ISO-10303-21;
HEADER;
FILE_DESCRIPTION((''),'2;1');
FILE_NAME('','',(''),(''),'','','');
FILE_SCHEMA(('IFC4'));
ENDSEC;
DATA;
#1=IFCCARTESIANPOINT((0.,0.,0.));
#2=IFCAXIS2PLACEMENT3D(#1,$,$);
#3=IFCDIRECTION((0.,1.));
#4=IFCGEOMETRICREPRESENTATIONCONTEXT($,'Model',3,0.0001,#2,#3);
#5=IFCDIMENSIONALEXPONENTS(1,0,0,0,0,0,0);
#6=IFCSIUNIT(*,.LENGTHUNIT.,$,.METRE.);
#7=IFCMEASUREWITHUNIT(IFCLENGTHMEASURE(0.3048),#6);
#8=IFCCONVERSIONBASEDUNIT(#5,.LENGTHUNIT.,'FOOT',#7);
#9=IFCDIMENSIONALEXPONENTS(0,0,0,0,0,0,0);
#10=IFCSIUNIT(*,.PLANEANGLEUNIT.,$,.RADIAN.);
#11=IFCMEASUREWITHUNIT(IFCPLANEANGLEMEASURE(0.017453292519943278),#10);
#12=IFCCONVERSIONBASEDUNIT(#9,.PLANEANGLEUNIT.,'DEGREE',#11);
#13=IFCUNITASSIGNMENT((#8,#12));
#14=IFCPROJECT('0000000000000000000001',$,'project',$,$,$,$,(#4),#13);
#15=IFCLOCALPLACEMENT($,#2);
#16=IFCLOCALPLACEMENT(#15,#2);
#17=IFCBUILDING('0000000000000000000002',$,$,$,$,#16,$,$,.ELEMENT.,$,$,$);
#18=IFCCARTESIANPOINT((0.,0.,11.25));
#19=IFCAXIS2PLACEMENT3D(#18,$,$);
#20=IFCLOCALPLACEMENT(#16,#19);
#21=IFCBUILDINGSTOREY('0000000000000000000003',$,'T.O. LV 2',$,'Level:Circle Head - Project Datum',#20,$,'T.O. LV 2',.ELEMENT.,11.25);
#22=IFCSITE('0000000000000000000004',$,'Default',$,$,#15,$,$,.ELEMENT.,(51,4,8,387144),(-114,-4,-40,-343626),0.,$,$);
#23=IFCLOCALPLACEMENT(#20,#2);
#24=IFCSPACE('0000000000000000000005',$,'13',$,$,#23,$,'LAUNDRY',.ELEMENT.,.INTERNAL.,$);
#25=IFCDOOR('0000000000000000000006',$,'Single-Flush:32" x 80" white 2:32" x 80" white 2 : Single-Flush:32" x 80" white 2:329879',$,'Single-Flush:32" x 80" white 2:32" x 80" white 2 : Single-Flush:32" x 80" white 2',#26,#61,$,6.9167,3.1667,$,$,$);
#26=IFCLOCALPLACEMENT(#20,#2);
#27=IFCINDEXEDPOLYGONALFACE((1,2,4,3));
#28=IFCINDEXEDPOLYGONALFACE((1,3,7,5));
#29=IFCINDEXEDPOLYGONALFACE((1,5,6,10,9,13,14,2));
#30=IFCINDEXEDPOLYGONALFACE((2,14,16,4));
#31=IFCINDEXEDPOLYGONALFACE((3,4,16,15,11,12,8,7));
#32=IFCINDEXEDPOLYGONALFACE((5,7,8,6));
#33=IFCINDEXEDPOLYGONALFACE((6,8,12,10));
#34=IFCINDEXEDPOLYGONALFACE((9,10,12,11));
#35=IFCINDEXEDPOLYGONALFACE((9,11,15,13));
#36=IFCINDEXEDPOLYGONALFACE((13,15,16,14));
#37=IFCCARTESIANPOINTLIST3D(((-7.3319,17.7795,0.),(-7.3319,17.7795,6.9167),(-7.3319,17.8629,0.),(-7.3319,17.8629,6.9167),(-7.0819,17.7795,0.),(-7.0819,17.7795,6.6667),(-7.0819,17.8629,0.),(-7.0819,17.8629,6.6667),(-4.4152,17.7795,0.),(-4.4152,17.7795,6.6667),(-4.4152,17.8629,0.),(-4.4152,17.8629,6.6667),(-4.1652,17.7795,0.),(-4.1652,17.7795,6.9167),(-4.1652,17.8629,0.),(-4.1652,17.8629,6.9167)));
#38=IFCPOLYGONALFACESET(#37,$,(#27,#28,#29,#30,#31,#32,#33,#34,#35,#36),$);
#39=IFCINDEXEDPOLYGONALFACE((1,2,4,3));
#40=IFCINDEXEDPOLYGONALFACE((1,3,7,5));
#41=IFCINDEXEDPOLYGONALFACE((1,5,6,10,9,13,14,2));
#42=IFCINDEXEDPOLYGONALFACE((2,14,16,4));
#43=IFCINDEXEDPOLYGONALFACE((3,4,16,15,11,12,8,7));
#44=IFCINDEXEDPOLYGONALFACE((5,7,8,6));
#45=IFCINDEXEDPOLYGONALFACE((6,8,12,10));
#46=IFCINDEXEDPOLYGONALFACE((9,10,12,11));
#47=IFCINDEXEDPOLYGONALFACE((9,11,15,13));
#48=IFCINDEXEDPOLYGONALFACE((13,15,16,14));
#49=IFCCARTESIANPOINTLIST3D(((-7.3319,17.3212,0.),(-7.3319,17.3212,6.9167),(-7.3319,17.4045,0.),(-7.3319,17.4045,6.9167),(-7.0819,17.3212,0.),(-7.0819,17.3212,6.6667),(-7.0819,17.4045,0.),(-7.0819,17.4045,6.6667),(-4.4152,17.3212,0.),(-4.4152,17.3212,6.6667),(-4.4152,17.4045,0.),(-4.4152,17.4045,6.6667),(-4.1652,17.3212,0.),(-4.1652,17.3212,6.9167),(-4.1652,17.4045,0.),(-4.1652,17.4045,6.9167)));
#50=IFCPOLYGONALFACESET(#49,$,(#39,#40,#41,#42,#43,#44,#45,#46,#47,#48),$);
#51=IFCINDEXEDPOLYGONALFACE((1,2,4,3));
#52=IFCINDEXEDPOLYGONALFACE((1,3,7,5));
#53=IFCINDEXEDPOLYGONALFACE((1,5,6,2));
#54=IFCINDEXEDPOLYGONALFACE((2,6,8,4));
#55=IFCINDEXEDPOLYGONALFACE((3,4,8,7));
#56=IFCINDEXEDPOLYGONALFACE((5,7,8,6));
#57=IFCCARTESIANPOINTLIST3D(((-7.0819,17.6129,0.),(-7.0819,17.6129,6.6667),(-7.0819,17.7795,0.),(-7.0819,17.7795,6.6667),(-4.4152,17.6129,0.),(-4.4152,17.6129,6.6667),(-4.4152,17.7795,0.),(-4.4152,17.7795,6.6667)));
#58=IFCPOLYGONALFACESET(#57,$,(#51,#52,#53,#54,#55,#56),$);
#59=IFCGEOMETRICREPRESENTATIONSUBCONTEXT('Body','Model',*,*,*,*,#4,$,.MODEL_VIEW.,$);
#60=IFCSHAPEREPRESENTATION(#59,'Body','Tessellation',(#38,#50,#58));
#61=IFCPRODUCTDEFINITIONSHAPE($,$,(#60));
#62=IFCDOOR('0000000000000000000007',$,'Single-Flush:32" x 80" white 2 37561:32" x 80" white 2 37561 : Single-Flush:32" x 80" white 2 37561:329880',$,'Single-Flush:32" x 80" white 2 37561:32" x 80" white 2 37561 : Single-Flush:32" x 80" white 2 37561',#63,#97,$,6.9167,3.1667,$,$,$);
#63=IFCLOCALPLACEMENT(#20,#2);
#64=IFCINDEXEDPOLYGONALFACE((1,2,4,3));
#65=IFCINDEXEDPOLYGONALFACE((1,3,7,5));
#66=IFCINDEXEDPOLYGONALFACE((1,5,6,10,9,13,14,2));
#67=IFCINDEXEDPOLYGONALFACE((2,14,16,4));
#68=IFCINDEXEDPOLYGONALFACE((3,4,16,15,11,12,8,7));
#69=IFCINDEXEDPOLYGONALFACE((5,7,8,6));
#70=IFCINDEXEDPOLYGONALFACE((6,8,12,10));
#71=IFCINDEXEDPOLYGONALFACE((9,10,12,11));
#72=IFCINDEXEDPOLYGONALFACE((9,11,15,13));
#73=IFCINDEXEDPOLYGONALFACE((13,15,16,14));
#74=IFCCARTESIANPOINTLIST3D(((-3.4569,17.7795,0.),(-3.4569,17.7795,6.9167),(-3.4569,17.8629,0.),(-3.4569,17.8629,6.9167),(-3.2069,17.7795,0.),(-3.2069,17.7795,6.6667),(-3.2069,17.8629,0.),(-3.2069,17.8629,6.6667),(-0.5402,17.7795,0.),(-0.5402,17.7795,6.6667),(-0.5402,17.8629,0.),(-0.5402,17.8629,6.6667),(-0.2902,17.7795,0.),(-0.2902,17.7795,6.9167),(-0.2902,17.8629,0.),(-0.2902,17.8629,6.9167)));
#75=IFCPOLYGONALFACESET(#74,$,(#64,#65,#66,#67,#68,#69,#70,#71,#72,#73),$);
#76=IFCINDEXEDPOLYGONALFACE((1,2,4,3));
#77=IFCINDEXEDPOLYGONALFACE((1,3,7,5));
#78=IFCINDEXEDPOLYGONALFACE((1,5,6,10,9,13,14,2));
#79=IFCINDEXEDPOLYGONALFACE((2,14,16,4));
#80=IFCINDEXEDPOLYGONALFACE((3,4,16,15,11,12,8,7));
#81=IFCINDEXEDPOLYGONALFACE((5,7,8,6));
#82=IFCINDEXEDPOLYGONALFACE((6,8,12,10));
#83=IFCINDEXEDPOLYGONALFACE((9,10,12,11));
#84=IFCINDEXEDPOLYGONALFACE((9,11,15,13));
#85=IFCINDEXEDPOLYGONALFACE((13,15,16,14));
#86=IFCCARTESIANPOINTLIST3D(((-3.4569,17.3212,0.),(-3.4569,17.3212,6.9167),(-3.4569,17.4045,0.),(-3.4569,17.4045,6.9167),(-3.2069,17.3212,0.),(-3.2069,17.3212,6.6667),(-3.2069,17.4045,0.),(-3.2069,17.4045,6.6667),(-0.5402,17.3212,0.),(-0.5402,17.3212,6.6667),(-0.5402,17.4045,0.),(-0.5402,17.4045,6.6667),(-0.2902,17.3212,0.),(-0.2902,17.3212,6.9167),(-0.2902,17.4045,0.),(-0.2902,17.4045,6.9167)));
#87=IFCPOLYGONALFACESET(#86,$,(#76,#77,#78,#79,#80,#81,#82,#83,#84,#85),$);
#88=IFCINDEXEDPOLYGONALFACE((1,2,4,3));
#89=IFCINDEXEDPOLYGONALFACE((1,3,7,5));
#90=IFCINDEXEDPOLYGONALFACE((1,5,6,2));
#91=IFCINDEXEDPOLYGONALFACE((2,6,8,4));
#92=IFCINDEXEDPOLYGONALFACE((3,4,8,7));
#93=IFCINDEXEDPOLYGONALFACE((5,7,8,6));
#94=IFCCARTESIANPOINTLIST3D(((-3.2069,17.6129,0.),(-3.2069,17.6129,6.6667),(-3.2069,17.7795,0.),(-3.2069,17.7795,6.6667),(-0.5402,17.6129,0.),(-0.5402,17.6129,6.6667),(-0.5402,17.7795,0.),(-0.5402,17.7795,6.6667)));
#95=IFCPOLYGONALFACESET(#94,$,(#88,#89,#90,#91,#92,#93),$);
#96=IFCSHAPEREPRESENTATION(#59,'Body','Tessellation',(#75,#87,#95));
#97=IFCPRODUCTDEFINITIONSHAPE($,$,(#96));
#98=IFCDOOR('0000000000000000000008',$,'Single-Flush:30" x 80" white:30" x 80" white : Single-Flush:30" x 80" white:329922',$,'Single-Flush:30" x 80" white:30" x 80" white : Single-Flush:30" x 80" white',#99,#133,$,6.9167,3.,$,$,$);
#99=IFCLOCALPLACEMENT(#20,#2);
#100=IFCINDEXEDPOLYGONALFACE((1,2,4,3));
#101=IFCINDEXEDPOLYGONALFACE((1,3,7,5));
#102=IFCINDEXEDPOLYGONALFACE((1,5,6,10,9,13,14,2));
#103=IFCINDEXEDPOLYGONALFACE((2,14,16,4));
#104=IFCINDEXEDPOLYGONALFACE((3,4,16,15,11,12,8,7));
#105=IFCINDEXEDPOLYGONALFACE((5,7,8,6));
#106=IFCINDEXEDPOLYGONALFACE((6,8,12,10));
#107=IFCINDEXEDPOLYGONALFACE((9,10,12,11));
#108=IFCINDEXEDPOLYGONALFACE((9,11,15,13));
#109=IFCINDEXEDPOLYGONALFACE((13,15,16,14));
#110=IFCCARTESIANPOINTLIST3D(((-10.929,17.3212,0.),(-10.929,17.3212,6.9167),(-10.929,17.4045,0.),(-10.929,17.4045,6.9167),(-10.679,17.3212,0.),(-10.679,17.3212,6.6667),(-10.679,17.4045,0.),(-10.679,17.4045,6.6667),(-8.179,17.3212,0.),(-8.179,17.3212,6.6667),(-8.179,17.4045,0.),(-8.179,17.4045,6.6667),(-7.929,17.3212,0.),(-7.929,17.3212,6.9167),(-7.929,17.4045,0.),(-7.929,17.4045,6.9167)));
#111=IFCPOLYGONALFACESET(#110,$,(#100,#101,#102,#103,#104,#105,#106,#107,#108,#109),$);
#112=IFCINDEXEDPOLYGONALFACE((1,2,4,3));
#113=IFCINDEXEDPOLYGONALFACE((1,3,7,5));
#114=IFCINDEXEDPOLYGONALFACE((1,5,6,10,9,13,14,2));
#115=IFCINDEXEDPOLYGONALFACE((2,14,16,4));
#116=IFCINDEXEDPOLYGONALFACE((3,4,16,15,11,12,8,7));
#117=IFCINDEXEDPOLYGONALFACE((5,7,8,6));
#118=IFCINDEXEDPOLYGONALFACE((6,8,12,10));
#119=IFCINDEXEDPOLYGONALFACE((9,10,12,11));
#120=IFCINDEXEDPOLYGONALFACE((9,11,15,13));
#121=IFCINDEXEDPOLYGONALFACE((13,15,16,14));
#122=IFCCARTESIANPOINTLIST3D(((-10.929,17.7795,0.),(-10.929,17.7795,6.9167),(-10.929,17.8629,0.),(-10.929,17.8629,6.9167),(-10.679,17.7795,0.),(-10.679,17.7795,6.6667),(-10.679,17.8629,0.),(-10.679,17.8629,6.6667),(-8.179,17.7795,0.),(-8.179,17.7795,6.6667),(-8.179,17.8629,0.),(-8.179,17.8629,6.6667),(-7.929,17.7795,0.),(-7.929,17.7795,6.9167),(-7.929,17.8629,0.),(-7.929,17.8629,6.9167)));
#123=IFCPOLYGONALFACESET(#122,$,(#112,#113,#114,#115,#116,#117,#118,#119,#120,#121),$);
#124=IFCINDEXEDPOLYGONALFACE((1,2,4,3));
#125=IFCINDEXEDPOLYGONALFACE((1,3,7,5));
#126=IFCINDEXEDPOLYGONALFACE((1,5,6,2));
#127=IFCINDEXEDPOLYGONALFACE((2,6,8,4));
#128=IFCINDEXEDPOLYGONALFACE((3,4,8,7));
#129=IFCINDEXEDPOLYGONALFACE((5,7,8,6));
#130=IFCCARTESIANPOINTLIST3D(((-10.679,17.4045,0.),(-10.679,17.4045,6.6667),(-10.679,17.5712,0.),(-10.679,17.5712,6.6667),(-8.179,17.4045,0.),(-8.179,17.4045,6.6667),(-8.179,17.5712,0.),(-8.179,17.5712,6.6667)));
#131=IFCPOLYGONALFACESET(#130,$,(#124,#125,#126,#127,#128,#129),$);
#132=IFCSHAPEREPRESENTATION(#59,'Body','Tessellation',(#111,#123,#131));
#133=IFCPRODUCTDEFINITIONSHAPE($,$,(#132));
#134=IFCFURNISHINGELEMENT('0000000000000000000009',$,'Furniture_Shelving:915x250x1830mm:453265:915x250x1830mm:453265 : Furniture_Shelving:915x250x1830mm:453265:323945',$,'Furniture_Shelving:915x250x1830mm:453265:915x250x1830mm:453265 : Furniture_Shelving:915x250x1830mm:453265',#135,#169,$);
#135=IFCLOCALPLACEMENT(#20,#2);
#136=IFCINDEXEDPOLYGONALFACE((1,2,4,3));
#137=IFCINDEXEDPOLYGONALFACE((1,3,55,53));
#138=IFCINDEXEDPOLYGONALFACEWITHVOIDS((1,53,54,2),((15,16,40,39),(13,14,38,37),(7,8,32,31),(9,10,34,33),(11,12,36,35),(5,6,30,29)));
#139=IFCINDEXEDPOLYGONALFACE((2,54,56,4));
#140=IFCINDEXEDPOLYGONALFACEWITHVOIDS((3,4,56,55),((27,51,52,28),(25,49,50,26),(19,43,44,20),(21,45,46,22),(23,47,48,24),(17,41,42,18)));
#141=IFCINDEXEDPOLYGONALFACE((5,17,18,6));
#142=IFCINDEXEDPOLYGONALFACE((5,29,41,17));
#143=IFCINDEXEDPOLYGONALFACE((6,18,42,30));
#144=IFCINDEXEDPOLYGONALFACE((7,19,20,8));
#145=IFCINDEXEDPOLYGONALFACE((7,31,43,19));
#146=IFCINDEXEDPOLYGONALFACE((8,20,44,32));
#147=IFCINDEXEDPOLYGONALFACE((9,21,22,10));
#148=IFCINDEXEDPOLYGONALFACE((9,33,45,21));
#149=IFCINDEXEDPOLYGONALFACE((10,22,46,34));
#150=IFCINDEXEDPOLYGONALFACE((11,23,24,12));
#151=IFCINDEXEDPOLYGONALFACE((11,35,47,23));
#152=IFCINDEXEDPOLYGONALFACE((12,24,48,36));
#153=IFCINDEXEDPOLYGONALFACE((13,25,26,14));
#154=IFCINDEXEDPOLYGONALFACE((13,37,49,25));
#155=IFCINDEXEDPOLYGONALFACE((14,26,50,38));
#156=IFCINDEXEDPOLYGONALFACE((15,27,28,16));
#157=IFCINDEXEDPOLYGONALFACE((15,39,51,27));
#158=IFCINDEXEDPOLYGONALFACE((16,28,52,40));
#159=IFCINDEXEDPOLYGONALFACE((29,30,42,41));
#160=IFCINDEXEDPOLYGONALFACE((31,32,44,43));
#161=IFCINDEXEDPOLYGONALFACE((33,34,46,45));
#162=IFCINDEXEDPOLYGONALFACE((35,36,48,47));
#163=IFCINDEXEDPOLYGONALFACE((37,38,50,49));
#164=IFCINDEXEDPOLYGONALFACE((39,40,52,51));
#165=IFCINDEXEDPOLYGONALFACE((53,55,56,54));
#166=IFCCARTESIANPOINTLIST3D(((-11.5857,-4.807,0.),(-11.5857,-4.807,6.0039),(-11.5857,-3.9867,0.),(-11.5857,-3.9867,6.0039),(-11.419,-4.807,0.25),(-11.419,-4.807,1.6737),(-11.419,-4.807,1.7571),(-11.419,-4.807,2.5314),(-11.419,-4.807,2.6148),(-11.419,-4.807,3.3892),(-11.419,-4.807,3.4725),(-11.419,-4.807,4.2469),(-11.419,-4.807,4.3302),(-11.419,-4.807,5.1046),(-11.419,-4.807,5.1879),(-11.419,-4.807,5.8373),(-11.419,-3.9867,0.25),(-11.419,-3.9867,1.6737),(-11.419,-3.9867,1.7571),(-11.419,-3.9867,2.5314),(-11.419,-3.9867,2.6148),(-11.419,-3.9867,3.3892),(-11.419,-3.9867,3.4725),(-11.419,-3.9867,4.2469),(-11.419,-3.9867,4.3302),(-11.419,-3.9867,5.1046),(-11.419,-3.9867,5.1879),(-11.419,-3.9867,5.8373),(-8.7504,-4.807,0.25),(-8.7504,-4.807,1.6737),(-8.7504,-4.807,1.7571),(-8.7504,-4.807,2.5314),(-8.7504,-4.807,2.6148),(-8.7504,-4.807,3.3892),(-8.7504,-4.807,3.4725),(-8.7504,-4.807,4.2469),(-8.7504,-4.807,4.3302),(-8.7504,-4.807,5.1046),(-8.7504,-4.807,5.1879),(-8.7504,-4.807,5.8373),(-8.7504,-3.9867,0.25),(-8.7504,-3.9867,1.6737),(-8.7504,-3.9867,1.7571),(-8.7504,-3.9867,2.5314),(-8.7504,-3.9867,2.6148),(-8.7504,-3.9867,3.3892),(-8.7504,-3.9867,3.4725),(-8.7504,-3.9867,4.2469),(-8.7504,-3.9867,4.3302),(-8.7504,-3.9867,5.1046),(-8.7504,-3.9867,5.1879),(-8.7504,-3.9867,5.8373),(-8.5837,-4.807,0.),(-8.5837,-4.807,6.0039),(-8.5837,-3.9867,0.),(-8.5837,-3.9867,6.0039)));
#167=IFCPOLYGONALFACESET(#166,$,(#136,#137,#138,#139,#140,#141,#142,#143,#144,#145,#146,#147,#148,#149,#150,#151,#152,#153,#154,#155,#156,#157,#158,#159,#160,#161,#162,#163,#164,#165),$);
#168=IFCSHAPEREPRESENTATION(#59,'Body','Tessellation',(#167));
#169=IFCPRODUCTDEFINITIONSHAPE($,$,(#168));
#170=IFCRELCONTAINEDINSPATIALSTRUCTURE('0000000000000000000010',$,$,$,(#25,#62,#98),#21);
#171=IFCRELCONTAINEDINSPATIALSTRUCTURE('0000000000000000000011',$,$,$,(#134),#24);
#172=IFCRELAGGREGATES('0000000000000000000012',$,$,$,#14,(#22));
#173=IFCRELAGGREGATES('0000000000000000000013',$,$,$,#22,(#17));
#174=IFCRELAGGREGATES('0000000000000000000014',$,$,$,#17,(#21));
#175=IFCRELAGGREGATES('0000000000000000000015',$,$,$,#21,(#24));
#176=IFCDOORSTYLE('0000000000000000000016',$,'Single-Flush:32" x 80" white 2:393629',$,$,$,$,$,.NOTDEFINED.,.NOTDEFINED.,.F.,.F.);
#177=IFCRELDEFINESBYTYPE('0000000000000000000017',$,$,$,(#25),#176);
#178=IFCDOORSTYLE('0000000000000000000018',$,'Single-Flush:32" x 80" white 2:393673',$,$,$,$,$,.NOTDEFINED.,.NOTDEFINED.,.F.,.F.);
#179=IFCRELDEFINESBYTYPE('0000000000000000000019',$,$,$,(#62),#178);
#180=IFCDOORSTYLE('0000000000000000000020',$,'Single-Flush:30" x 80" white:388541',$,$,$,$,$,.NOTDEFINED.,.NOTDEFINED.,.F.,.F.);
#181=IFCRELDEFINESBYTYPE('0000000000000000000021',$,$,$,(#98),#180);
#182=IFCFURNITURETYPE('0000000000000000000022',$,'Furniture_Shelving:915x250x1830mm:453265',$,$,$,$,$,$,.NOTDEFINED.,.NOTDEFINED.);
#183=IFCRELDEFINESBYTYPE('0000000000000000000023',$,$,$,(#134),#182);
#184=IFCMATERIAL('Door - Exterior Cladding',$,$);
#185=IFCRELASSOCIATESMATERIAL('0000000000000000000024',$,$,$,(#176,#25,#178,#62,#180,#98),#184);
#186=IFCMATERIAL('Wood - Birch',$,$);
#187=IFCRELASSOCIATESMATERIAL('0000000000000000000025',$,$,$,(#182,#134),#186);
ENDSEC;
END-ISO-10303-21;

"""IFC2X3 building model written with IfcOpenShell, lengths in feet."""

from ifc_helpers import new_model, entity, si_unit, converted_unit, direction, frame, frame_2d, origin, origin_2d_with_axis, place, context, subcontext, project, spatial, polyline, rectangle, outline, extrude, source, transform, mapped, material, type_object, type_shapes, element, save


model = new_model("IFC2X3")

# Units and contexts
model_context = context("Model", 3, precision=0.0001, world=origin(), true_north=direction((0.0, 1.0)))
body_context = subcontext(model_context, "Body", "Model", "MODEL_VIEW")
ifc_project = project(units=[converted_unit("LENGTHUNIT", "FOOT", entity("IfcLengthMeasure", 0.3048), si_unit("LENGTHUNIT", "METRE"), dimensions=[1, 0, 0, 0, 0, 0, 0]), converted_unit("PLANEANGLEUNIT", "DEGREE", entity("IfcPlaneAngleMeasure", 0.017453292519943278), si_unit("PLANEANGLEUNIT", "RADIAN"), dimensions=[0, 0, 0, 0, 0, 0, 0])], contexts=[model_context])

# Site, building, storey
site_placement = place(None, origin())
site = spatial("IfcSite", under=ifc_project, at=site_placement, Name="Default", CompositionType="ELEMENT", RefLatitude=(51, 4, 8, 387144), RefLongitude=(-114, -4, -40, -343626), RefElevation=0.0)
building_placement = place(site_placement, origin())
building = spatial("IfcBuilding", under=site, at=building_placement, CompositionType="ELEMENT")
storey_placement = place(building_placement, frame((0.0, 0.0, 11.25)))
storey = spatial("IfcBuildingStorey", under=building, at=storey_placement, Name="T.O. LV 2", ObjectType="Level:Circle Head - Project Datum", LongName="T.O. LV 2", CompositionType="ELEMENT", Elevation=11.25)

# Shared definitions
ifc_material_1 = material(Name="Door - Exterior Cladding")

# Doors
door_style_1 = type_object("IfcDoorStyle", Name="Single-Flush:32\" x 80\" white 2:393629", ConstructionType="NOTDEFINED", OperationType="NOTDEFINED", ParameterTakesPrecedence=False, Sizeable=False, material=ifc_material_1)
shared_shape_1 = source(origin(), body_context, "Body", "SweptSolid", [
    extrude(outline(polyline([(-3.5208, -1.5833), (3.3958, -1.5833), (3.3958, -1.3333), (-3.2708, -1.3333), (-3.2708, 1.3333), (3.3958, 1.3333), (3.3958, 1.5833), (-3.5208, 1.5833), (-3.5208, -1.5833)])), frame((1.3333, 0.3788, 3.3958), z_axis=(0.0, 1.0, 0.0), x_axis=(0.0, 0.0, -1.0)), (0.0, 0.0, 1.0), 0.0833),
    extrude(outline(polyline([(-1.5833, -3.3958), (-1.3333, -3.3958), (-1.3333, 3.2708), (1.3333, 3.2708), (1.3333, -3.3958), (1.5833, -3.3958), (1.5833, 3.5208), (-1.5833, 3.5208), (-1.5833, -3.3958)])), frame((1.3333, -0.0796, 3.3958), z_axis=(0.0, 1.0, 0.0), x_axis=(-1.0, 0.0, 0.0)), (0.0, 0.0, 1.0), 0.0833),
    extrude(rectangle(XDim=2.6667, YDim=0.1667, at=frame_2d((0.0, 0.0), x_axis=(1.0, 0.0))), frame((1.3333, 0.2954, 0.0), z_axis=(0.0, 0.0, 1.0), x_axis=(-1.0, 0.0, 0.0)), (0.0, 0.0, 1.0), 6.6667),
])
type_shapes(door_style_1, [shared_shape_1])
door_1_placement = place(storey_placement, frame((-7.0819, 17.4008, 0.0)))
element("IfcDoor", 1, at=door_1_placement, inside=storey, type_object=door_style_1, material=ifc_material_1, Name="Single-Flush:32\" x 80\" white 2:32\" x 80\" white 2 : Single-Flush:32\" x 80\" white 2:329879", ObjectType="Single-Flush:32\" x 80\" white 2:32\" x 80\" white 2 : Single-Flush:32\" x 80\" white 2", OverallHeight=6.9167, OverallWidth=3.1667, context=body_context, shape_type="MappedRepresentation", body=[
    mapped(shared_shape_1, transform((0.0, 0.0, 0.0), scale=1.0)),
])
door_style_2 = type_object("IfcDoorStyle", Name="Single-Flush:32\" x 80\" white 2:393673", ConstructionType="NOTDEFINED", OperationType="NOTDEFINED", ParameterTakesPrecedence=False, Sizeable=False, material=ifc_material_1)
shared_shape_2 = source(origin(), body_context, "Body", "SweptSolid", [
    extrude(outline(polyline([(-1.5833, -3.5208), (1.5833, -3.5208), (1.5833, 3.3958), (1.3333, 3.3958), (1.3333, -3.2708), (-1.3333, -3.2708), (-1.3333, 3.3958), (-1.5833, 3.3958), (-1.5833, -3.5208)])), frame((1.3333, 0.3787, 3.3958), z_axis=(0.0, 1.0, 0.0), x_axis=(1.0, 0.0, 0.0)), (0.0, 0.0, 1.0), 0.0833),
    extrude(outline(polyline([(-3.3958, -1.5833), (3.5208, -1.5833), (3.5208, 1.5833), (-3.3958, 1.5833), (-3.3958, 1.3333), (3.2708, 1.3333), (3.2708, -1.3333), (-3.3958, -1.3333), (-3.3958, -1.5833)])), frame((1.3333, -0.0796, 3.3958), z_axis=(0.0, 1.0, 0.0), x_axis=(0.0, 0.0, 1.0)), (0.0, 0.0, 1.0), 0.0833),
    extrude(rectangle(XDim=0.1667, YDim=2.6667, at=frame_2d((0.0, 0.0), x_axis=(1.0, 0.0))), frame((1.3333, 0.2954, 0.0), z_axis=(0.0, 0.0, 1.0), x_axis=(0.0, 1.0, 0.0)), (0.0, 0.0, 1.0), 6.6667),
])
type_shapes(door_style_2, [shared_shape_2])
door_2_placement = place(storey_placement, frame((-3.2069, 17.4008, 0.0)))
element("IfcDoor", 2, at=door_2_placement, inside=storey, type_object=door_style_2, material=ifc_material_1, Name="Single-Flush:32\" x 80\" white 2 37561:32\" x 80\" white 2 37561 : Single-Flush:32\" x 80\" white 2 37561:329880", ObjectType="Single-Flush:32\" x 80\" white 2 37561:32\" x 80\" white 2 37561 : Single-Flush:32\" x 80\" white 2 37561", OverallHeight=6.9167, OverallWidth=3.1667, context=body_context, shape_type="MappedRepresentation", body=[
    mapped(shared_shape_2, transform((0.0, 0.0, 0.0), scale=1.0)),
])
door_style_3 = type_object("IfcDoorStyle", Name="Single-Flush:30\" x 80\" white:388541", ConstructionType="NOTDEFINED", OperationType="NOTDEFINED", ParameterTakesPrecedence=False, Sizeable=False, material=ifc_material_1)
shared_shape_3 = source(origin(), body_context, "Body", "SweptSolid", [
    extrude(outline(polyline([(-3.5208, -1.5), (3.3958, -1.5), (3.3958, -1.25), (-3.2708, -1.25), (-3.2708, 1.25), (3.3958, 1.25), (3.3958, 1.5), (-3.5208, 1.5), (-3.5208, -1.5)])), frame((1.25, -0.0037, 3.3958), z_axis=(0.0, 1.0, 0.0), x_axis=(0.0, 0.0, -1.0)), (0.0, 0.0, 1.0), 0.0833),
    extrude(outline(polyline([(-1.5, -3.3958), (-1.25, -3.3958), (-1.25, 3.2708), (1.25, 3.2708), (1.25, -3.3958), (1.5, -3.3958), (1.5, 3.5208), (-1.5, 3.5208), (-1.5, -3.3958)])), frame((1.25, -0.4621, 3.3958), z_axis=(0.0, 1.0, 0.0), x_axis=(-1.0, 0.0, 0.0)), (0.0, 0.0, 1.0), 0.0833),
    extrude(rectangle(XDim=2.5, YDim=0.1667, at=origin_2d_with_axis()), frame((1.25, -0.0871, 0.0), z_axis=(0.0, 0.0, 1.0), x_axis=(-1.0, 0.0, 0.0)), (0.0, 0.0, 1.0), 6.6667),
])
type_shapes(door_style_3, [shared_shape_3])
door_3_placement = place(storey_placement, frame((-8.179, 17.4008, 0.0), z_axis=(0.0, 0.0, 1.0), x_axis=(-1.0, 0.0, 0.0)))
element("IfcDoor", 3, at=door_3_placement, inside=storey, type_object=door_style_3, material=ifc_material_1, Name="Single-Flush:30\" x 80\" white:30\" x 80\" white : Single-Flush:30\" x 80\" white:329922", ObjectType="Single-Flush:30\" x 80\" white:30\" x 80\" white : Single-Flush:30\" x 80\" white", OverallHeight=6.9167, OverallWidth=3.0, context=body_context, shape_type="MappedRepresentation", body=[
    mapped(shared_shape_3, transform((0.0, 0.0, 0.0), scale=1.0)),
])

# Shared definitions
space_placement = place(storey_placement, origin())
space = spatial("IfcSpace", under=storey, at=space_placement, Name="13", LongName="LAUNDRY", CompositionType="ELEMENT", InteriorOrExteriorSpace="INTERNAL")

# Furnishing element
ifc_material_2 = material(Name="Wood - Birch")
furniture_type = type_object("IfcFurnitureType", Name="Furniture_Shelving:915x250x1830mm:453265", AssemblyPlace="NOTDEFINED", material=ifc_material_2)
shared_shape_4 = source(origin(), body_context, "Body", "SweptSolid", [
    extrude(outline(polyline([(-3.002, -1.501), (3.002, -1.501), (3.002, 1.501), (-3.002, 1.501), (-3.002, -1.501)]), holes=[polyline([(2.8353, -1.3343), (2.1859, -1.3343), (2.1859, 1.3343), (2.8353, 1.3343), (2.8353, -1.3343)]), polyline([(-1.3282, 1.3343), (-1.3282, -1.3343), (-2.752, -1.3343), (-2.752, 1.3343), (-1.3282, 1.3343)]), polyline([(0.4705, 1.3343), (1.2449, 1.3343), (1.2449, -1.3343), (0.4705, -1.3343), (0.4705, 1.3343)]), polyline([(2.1026, -1.3343), (1.3282, -1.3343), (1.3282, 1.3343), (2.1026, 1.3343), (2.1026, -1.3343)]), polyline([(0.3872, -1.3343), (-0.3872, -1.3343), (-0.3872, 1.3343), (0.3872, 1.3343), (0.3872, -1.3343)]), polyline([(-0.4705, -1.3343), (-1.2449, -1.3343), (-1.2449, 1.3343), (-0.4705, 1.3343), (-0.4705, -1.3343)])]), frame((-10.0847, -4.807, 14.252), z_axis=(0.0, 1.0, 0.0), x_axis=(0.0, 0.0, 1.0)), (0.0, 0.0, 1.0), 0.8202),
])
type_shapes(furniture_type, [shared_shape_4])
furnishing_placement = place(space_placement, frame((0.0, 0.0, -11.25)))
element("IfcFurnishingElement", 4, at=furnishing_placement, inside=space, type_object=furniture_type, material=ifc_material_2, Name="Furniture_Shelving:915x250x1830mm:453265:915x250x1830mm:453265 : Furniture_Shelving:915x250x1830mm:453265:323945", ObjectType="Furniture_Shelving:915x250x1830mm:453265:915x250x1830mm:453265 : Furniture_Shelving:915x250x1830mm:453265", context=body_context, shape_type="MappedRepresentation", body=[
    mapped(shared_shape_4, transform((0.0, 0.0, 0.0), scale=1.0)),
])

save(model, "model.ifc")
